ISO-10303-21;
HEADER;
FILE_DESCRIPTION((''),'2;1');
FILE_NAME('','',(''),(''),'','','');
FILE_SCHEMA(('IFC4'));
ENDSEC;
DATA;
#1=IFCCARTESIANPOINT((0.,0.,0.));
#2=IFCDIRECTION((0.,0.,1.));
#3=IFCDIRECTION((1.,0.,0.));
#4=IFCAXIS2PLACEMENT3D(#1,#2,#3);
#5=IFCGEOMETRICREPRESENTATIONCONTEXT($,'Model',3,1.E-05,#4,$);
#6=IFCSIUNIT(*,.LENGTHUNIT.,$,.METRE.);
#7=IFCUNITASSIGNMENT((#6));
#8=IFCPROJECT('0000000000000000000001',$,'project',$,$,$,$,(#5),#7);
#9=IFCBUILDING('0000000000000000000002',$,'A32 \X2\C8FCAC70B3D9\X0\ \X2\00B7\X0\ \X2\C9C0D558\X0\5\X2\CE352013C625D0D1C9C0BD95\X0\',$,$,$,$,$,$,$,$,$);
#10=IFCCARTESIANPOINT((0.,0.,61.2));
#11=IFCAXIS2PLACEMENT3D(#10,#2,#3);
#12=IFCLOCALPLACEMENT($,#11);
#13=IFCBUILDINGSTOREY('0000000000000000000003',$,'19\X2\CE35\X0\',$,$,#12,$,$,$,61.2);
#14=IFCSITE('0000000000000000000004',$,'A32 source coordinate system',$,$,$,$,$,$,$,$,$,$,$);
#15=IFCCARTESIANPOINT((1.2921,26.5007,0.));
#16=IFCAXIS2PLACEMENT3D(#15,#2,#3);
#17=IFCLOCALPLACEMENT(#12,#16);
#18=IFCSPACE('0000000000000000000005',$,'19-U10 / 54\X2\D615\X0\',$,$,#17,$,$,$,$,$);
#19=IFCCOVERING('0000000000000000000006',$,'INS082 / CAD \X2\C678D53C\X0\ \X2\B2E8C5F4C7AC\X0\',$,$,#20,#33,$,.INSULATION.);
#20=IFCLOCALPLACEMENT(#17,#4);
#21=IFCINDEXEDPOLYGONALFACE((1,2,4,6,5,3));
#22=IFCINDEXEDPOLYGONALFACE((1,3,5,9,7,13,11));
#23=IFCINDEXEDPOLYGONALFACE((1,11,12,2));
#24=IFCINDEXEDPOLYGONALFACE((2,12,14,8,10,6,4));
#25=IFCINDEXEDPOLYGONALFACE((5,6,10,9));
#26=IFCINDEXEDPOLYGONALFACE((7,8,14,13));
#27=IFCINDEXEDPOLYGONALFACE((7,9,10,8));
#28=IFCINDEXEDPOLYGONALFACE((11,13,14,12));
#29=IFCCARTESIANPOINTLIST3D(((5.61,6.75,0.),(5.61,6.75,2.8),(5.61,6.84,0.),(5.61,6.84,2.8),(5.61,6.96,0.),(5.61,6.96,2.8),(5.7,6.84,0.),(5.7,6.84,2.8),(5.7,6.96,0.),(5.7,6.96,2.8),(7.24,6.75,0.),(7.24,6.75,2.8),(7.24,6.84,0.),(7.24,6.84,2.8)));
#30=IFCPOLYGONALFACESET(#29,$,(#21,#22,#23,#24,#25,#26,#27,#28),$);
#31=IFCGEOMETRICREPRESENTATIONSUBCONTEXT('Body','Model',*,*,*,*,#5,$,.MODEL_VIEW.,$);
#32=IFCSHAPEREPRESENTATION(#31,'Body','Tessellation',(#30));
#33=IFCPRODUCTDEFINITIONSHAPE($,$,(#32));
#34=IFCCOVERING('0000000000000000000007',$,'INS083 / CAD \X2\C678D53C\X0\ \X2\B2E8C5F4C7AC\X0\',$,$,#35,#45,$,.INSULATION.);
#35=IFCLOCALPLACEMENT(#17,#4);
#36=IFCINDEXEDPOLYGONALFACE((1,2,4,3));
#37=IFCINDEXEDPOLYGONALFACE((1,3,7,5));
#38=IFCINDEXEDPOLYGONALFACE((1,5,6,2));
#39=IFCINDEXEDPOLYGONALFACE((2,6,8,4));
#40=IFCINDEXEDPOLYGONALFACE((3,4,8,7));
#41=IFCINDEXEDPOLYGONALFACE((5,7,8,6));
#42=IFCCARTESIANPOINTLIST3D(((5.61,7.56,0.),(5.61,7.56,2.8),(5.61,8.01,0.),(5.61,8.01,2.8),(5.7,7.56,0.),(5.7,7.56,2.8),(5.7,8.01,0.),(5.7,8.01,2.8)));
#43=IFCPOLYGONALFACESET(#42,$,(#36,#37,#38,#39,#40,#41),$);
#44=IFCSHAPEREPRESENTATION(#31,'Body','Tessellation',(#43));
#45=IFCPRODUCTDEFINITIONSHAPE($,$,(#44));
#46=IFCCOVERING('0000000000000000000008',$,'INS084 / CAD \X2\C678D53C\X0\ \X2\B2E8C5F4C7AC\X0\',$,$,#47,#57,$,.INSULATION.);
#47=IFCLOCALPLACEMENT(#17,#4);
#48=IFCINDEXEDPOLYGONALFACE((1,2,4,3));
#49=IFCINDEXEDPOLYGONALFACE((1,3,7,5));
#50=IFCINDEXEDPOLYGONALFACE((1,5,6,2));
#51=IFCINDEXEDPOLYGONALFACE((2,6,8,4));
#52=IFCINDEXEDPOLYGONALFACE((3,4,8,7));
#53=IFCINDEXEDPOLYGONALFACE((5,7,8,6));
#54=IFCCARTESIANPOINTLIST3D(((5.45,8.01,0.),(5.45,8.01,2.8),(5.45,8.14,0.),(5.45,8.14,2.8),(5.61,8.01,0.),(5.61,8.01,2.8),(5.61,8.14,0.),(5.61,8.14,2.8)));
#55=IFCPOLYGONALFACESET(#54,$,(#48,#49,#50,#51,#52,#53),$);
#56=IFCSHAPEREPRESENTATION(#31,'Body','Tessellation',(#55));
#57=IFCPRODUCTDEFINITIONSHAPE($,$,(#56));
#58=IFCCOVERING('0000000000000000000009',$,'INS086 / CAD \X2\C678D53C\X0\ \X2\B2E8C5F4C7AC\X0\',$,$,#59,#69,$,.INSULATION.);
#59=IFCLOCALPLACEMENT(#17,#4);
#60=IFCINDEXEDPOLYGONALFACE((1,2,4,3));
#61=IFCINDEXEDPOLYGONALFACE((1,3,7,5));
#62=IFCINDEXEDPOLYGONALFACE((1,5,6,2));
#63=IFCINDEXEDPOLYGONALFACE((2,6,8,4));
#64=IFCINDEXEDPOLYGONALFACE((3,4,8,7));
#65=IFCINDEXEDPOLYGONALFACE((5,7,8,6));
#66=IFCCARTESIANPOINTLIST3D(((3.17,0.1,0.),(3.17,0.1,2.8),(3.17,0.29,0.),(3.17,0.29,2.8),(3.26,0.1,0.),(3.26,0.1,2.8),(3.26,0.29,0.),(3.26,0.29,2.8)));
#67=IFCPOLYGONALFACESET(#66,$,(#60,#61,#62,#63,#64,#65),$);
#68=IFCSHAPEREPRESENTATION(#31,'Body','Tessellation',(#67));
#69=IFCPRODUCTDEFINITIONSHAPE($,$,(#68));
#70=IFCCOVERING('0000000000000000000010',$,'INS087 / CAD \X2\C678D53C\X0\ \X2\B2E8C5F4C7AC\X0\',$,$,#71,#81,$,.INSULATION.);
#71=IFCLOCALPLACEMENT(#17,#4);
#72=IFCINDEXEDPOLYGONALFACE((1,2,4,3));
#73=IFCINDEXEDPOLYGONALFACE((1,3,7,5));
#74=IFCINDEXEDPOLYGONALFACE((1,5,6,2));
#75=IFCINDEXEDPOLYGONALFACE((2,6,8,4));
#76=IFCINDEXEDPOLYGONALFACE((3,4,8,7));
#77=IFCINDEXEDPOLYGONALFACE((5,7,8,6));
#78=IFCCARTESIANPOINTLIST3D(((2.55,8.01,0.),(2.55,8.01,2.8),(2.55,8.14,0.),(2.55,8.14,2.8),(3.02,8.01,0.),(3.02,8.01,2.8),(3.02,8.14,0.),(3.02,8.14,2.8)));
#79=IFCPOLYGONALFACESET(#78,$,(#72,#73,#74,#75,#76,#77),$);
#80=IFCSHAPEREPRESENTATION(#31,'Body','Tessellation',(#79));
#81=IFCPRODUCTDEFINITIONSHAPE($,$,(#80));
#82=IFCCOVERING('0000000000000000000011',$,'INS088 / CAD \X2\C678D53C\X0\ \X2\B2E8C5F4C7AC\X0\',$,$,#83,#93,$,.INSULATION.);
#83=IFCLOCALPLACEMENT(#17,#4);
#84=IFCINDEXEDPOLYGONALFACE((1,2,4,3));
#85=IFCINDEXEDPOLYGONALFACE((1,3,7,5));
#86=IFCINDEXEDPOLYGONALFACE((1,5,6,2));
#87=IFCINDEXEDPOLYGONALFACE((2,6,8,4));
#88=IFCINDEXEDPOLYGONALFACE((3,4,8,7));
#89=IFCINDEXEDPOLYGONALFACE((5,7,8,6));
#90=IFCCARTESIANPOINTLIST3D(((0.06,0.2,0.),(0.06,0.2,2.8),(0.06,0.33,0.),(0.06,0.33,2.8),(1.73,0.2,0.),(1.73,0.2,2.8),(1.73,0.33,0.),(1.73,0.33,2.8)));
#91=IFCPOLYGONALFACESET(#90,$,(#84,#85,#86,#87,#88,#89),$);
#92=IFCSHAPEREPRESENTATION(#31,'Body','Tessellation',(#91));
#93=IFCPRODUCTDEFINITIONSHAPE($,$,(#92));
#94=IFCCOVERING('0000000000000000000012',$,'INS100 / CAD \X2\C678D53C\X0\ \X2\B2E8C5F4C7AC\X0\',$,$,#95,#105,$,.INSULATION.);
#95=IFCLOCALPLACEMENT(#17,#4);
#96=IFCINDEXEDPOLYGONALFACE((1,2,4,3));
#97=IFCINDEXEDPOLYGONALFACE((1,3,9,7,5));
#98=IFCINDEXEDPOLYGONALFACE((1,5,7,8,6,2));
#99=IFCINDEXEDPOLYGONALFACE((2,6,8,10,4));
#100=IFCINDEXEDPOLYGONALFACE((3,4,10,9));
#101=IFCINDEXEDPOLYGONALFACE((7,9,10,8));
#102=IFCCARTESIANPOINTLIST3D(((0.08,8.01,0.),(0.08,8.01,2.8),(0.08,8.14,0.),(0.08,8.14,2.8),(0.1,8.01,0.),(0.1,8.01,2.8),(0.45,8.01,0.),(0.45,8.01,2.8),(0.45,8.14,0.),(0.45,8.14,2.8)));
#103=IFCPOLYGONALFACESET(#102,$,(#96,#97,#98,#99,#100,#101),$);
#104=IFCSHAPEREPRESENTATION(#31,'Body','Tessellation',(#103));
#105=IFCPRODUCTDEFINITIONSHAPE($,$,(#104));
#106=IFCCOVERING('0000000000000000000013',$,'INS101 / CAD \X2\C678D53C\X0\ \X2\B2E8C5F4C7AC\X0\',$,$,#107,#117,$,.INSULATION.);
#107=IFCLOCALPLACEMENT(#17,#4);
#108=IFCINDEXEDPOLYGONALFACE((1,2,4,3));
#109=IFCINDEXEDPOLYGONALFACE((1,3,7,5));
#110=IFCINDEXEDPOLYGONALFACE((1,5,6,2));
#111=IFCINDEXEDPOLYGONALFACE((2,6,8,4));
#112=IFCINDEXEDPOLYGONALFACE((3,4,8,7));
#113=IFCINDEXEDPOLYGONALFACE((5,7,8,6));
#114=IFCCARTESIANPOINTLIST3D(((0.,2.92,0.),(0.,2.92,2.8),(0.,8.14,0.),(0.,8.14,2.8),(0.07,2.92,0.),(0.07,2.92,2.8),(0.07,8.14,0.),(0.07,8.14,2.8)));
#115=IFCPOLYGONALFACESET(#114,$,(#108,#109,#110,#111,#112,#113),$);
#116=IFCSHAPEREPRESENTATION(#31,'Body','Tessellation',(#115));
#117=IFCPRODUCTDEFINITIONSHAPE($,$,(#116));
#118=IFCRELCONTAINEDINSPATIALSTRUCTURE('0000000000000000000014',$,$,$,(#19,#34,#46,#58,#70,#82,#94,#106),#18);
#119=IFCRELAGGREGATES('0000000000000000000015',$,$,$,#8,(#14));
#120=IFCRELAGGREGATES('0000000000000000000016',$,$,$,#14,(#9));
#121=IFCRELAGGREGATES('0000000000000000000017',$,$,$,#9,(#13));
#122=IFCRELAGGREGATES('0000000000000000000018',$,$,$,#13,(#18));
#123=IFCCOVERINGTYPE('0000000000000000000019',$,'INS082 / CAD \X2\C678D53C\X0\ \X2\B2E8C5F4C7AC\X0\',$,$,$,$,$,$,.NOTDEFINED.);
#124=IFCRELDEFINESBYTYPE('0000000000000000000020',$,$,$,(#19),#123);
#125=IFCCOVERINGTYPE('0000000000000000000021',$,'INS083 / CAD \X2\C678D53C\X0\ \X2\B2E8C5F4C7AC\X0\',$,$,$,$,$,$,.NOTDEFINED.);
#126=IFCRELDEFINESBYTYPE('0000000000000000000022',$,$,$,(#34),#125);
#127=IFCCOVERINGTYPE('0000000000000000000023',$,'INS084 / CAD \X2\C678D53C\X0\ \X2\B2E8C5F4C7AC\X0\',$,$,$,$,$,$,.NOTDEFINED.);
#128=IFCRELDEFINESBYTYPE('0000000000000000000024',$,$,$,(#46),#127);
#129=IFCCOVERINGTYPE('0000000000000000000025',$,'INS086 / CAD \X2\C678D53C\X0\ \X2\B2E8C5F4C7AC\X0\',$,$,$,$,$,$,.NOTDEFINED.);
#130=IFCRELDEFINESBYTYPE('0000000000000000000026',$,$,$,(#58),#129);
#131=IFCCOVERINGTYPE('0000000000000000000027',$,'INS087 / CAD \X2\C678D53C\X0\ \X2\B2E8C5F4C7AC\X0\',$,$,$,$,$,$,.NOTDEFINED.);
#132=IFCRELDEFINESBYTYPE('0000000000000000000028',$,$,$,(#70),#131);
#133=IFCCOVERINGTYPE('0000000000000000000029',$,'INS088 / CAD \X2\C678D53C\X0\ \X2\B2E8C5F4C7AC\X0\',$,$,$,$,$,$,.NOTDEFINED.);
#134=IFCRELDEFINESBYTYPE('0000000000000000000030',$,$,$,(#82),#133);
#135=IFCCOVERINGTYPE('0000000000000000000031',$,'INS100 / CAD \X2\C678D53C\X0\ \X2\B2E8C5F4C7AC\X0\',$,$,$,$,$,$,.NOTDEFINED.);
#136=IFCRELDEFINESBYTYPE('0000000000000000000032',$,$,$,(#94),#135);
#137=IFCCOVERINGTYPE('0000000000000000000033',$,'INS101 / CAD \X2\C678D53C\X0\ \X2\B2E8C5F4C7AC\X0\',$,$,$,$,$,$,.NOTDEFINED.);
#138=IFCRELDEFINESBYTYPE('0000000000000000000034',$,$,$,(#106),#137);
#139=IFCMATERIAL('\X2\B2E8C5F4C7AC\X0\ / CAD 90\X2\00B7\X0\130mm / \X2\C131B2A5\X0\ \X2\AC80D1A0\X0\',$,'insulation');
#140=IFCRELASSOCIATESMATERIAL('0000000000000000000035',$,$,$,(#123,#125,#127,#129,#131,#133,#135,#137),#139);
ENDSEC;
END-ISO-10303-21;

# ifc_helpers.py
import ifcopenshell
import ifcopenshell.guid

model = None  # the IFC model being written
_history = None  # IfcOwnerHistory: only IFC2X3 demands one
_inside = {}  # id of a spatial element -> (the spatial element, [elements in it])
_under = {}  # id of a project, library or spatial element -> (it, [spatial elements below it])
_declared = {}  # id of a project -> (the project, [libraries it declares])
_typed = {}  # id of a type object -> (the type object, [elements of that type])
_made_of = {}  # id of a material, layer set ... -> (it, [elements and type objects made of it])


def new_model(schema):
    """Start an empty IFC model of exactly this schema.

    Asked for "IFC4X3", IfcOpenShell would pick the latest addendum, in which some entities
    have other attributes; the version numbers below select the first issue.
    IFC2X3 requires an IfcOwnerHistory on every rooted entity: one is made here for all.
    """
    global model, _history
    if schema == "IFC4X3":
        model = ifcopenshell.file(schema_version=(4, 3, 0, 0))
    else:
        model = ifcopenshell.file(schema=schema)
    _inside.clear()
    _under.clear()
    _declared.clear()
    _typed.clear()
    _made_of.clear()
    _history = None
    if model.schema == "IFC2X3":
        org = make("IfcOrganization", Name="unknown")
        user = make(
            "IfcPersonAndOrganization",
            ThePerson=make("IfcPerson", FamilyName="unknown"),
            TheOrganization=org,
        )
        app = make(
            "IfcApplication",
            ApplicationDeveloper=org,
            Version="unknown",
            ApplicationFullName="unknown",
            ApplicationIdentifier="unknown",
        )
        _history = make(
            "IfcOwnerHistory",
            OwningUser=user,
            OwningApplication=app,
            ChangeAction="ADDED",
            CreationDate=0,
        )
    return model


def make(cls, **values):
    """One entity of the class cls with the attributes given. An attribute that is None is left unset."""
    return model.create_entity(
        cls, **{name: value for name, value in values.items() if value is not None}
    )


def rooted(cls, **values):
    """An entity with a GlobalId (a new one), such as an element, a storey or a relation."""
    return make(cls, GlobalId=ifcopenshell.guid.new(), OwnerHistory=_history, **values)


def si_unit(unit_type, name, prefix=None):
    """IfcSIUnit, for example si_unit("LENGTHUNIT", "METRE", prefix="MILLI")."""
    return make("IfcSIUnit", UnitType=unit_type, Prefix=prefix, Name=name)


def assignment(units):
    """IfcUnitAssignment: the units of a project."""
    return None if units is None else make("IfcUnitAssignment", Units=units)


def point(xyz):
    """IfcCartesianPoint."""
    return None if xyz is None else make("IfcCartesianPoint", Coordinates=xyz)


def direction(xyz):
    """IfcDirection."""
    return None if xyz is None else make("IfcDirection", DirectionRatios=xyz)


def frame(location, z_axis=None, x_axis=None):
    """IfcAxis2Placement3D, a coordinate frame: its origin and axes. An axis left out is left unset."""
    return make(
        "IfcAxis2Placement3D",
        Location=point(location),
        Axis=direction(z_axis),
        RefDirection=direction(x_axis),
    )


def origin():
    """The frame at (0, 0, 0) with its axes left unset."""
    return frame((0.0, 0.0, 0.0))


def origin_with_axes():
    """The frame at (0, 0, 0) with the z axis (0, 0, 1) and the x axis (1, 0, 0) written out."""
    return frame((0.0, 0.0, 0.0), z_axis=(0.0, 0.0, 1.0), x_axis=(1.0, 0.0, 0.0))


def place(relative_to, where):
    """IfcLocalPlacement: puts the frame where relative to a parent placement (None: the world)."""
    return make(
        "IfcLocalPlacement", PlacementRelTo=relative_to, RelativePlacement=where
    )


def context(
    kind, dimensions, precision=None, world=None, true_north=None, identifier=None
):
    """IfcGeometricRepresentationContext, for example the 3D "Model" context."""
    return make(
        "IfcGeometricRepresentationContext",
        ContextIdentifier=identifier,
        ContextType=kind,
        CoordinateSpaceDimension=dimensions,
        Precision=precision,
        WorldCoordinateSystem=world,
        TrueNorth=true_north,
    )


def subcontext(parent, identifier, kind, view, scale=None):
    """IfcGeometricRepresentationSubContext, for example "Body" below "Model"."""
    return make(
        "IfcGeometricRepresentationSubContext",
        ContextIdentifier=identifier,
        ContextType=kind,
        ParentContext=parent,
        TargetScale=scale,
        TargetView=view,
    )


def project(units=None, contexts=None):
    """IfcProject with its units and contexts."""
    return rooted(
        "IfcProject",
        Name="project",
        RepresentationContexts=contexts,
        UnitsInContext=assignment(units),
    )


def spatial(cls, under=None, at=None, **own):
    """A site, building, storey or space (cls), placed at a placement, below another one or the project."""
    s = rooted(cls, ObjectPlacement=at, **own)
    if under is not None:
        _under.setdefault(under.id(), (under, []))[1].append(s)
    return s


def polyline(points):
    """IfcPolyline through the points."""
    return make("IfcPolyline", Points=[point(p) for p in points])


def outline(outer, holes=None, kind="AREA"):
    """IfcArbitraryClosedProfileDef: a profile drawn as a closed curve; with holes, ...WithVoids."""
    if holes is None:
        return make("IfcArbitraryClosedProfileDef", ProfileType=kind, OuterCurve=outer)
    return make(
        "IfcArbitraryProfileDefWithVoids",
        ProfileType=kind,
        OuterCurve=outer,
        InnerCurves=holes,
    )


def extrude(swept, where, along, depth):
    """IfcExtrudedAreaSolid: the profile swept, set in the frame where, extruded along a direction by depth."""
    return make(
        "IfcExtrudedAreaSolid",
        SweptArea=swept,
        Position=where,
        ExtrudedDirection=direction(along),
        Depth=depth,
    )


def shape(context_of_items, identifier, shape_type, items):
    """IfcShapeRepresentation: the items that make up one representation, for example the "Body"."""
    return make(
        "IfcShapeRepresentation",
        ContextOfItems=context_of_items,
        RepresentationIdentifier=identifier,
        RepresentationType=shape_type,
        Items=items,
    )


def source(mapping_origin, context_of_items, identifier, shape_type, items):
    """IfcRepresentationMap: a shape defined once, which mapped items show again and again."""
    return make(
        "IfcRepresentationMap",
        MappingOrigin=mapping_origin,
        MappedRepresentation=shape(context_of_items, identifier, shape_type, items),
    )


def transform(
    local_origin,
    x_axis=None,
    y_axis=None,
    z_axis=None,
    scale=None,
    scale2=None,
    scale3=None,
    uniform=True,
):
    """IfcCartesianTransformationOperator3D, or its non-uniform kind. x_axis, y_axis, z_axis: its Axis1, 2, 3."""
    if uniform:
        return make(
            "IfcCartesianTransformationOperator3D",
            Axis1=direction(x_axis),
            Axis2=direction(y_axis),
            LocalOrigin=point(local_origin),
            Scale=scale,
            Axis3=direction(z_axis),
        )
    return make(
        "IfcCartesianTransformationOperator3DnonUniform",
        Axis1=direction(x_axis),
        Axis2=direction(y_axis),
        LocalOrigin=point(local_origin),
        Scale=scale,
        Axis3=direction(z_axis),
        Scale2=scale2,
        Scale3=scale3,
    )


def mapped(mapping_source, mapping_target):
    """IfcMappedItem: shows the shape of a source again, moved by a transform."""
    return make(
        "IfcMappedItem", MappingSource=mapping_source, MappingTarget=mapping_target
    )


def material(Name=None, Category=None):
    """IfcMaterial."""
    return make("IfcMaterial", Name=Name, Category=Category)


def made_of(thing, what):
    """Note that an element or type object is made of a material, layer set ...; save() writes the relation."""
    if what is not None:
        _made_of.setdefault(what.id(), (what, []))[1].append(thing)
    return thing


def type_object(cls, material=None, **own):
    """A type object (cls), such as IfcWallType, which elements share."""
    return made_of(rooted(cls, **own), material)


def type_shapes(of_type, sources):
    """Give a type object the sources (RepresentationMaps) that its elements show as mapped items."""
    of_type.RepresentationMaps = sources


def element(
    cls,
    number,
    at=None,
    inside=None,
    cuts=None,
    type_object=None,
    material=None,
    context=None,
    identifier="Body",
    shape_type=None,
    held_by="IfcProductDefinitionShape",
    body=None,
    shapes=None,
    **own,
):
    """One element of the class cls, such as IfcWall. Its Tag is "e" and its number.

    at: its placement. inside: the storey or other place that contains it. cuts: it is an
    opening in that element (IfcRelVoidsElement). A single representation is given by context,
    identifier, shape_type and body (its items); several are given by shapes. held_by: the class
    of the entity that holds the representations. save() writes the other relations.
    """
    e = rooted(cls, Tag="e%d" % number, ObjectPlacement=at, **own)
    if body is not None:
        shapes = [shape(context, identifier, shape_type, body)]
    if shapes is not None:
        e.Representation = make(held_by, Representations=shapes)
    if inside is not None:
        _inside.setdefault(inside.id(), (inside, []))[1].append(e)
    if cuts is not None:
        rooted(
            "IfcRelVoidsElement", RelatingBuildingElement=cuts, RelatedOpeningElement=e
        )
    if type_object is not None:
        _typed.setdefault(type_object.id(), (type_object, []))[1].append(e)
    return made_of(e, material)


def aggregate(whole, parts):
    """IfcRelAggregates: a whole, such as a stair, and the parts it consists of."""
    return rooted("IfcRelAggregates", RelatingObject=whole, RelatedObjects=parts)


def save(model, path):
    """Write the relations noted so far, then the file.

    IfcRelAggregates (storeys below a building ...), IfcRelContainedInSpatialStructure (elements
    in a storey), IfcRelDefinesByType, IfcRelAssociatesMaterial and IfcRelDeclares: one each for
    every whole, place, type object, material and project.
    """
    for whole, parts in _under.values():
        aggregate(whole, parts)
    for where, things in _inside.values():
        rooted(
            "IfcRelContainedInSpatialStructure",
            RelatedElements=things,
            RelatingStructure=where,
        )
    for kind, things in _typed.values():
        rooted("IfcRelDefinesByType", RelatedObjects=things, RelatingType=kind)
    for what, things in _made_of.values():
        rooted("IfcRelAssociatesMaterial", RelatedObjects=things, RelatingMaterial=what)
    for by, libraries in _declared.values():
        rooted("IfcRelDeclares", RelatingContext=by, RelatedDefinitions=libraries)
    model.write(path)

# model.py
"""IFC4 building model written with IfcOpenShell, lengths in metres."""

from ifc_helpers import new_model, si_unit, frame, origin, origin_with_axes, place, context, subcontext, project, spatial, polyline, outline, extrude, source, transform, mapped, material, type_object, type_shapes, element, save


model = new_model("IFC4")

# Units and contexts
model_context = context("Model", 3, precision=1e-05, world=origin_with_axes())
body_context = subcontext(model_context, "Body", "Model", "MODEL_VIEW")
ifc_project = project(units=[si_unit("LENGTHUNIT", "METRE")], contexts=[model_context])

# Site, building, storey, space
storey_placement = place(None, frame((0.0, 0.0, 61.2), z_axis=(0.0, 0.0, 1.0), x_axis=(1.0, 0.0, 0.0)))
space_placement = place(storey_placement, frame((1.2921, 26.5007, 0.0), z_axis=(0.0, 0.0, 1.0), x_axis=(1.0, 0.0, 0.0)))
site = spatial("IfcSite", under=ifc_project, Name="A32 source coordinate system")
building = spatial("IfcBuilding", under=site, Name="A32 주거동 · 지하5층–옥탑지붕")
storey = spatial("IfcBuildingStorey", under=building, at=storey_placement, Name="19층", Elevation=61.2)
space = spatial("IfcSpace", under=storey, at=space_placement, Name="19-U10 / 54형")

# Coverings
ifc_material = material(Name="단열재 / CAD 90·130mm / 성능 검토", Category="insulation")
covering_type_1 = type_object("IfcCoveringType", Name="INS082 / CAD 외피 단열재", PredefinedType="NOTDEFINED", material=ifc_material)
shared_shape_1 = source(origin(), body_context, "Body", "SweptSolid", [
    extrude(outline(polyline([(5.61, 6.84), (5.61, 6.96), (5.7, 6.96), (5.7, 6.84), (7.24, 6.84), (7.24, 6.75), (5.61, 6.75), (5.61, 6.84)])), origin(), (0.0, 0.0, 1.0), 2.8),
])
type_shapes(covering_type_1, [shared_shape_1])
covering_1_placement = place(space_placement, origin_with_axes())
element("IfcCovering", 1, at=covering_1_placement, inside=space, type_object=covering_type_1, Name="INS082 / CAD 외피 단열재", PredefinedType="INSULATION", context=body_context, shape_type="MappedRepresentation", body=[
    mapped(shared_shape_1, transform((0.0, 0.0, 0.0), scale=1.0)),
])
covering_type_2 = type_object("IfcCoveringType", Name="INS083 / CAD 외피 단열재", PredefinedType="NOTDEFINED", material=ifc_material)
shared_shape_2 = source(origin(), body_context, "Body", "SweptSolid", [
    extrude(outline(polyline([(5.61, 8.01), (5.7, 8.01), (5.7, 7.56), (5.61, 7.56), (5.61, 8.01)])), origin(), (0.0, 0.0, 1.0), 2.8),
])
type_shapes(covering_type_2, [shared_shape_2])
covering_2_placement = place(space_placement, origin_with_axes())
element("IfcCovering", 2, at=covering_2_placement, inside=space, type_object=covering_type_2, Name="INS083 / CAD 외피 단열재", PredefinedType="INSULATION", context=body_context, shape_type="MappedRepresentation", body=[
    mapped(shared_shape_2, transform((0.0, 0.0, 0.0), scale=1.0)),
])
covering_type_3 = type_object("IfcCoveringType", Name="INS084 / CAD 외피 단열재", PredefinedType="NOTDEFINED", material=ifc_material)
shared_shape_3 = source(origin(), body_context, "Body", "SweptSolid", [
    extrude(outline(polyline([(5.45, 8.01), (5.45, 8.14), (5.61, 8.14), (5.61, 8.01), (5.45, 8.01)])), origin(), (0.0, 0.0, 1.0), 2.8),
])
type_shapes(covering_type_3, [shared_shape_3])
covering_3_placement = place(space_placement, origin_with_axes())
element("IfcCovering", 3, at=covering_3_placement, inside=space, type_object=covering_type_3, Name="INS084 / CAD 외피 단열재", PredefinedType="INSULATION", context=body_context, shape_type="MappedRepresentation", body=[
    mapped(shared_shape_3, transform((0.0, 0.0, 0.0), scale=1.0)),
])
covering_type_4 = type_object("IfcCoveringType", Name="INS086 / CAD 외피 단열재", PredefinedType="NOTDEFINED", material=ifc_material)
shared_shape_4 = source(origin(), body_context, "Body", "SweptSolid", [
    extrude(outline(polyline([(3.17, 0.1), (3.17, 0.29), (3.26, 0.29), (3.26, 0.1), (3.17, 0.1)])), origin(), (0.0, 0.0, 1.0), 2.8),
])
type_shapes(covering_type_4, [shared_shape_4])
covering_4_placement = place(space_placement, origin_with_axes())
element("IfcCovering", 4, at=covering_4_placement, inside=space, type_object=covering_type_4, Name="INS086 / CAD 외피 단열재", PredefinedType="INSULATION", context=body_context, shape_type="MappedRepresentation", body=[
    mapped(shared_shape_4, transform((0.0, 0.0, 0.0), scale=1.0)),
])
covering_type_5 = type_object("IfcCoveringType", Name="INS087 / CAD 외피 단열재", PredefinedType="NOTDEFINED", material=ifc_material)
shared_shape_5 = source(origin(), body_context, "Body", "SweptSolid", [
    extrude(outline(polyline([(2.55, 8.14), (3.02, 8.14), (3.02, 8.01), (2.55, 8.01), (2.55, 8.14)])), origin(), (0.0, 0.0, 1.0), 2.8),
])
type_shapes(covering_type_5, [shared_shape_5])
covering_5_placement = place(space_placement, origin_with_axes())
element("IfcCovering", 5, at=covering_5_placement, inside=space, type_object=covering_type_5, Name="INS087 / CAD 외피 단열재", PredefinedType="INSULATION", context=body_context, shape_type="MappedRepresentation", body=[
    mapped(shared_shape_5, transform((0.0, 0.0, 0.0), scale=1.0)),
])
covering_type_6 = type_object("IfcCoveringType", Name="INS088 / CAD 외피 단열재", PredefinedType="NOTDEFINED", material=ifc_material)
shared_shape_6 = source(origin(), body_context, "Body", "SweptSolid", [
    extrude(outline(polyline([(0.06, 0.33), (1.73, 0.33), (1.73, 0.2), (0.06, 0.2), (0.06, 0.33)])), origin(), (0.0, 0.0, 1.0), 2.8),
])
type_shapes(covering_type_6, [shared_shape_6])
covering_6_placement = place(space_placement, origin_with_axes())
element("IfcCovering", 6, at=covering_6_placement, inside=space, type_object=covering_type_6, Name="INS088 / CAD 외피 단열재", PredefinedType="INSULATION", context=body_context, shape_type="MappedRepresentation", body=[
    mapped(shared_shape_6, transform((0.0, 0.0, 0.0), scale=1.0)),
])
covering_type_7 = type_object("IfcCoveringType", Name="INS100 / CAD 외피 단열재", PredefinedType="NOTDEFINED", material=ifc_material)
shared_shape_7 = source(origin(), body_context, "Body", "SweptSolid", [
    extrude(outline(polyline([(0.08, 8.01), (0.08, 8.14), (0.45, 8.14), (0.45, 8.01), (0.1, 8.01), (0.08, 8.01)])), origin(), (0.0, 0.0, 1.0), 2.8),
])
type_shapes(covering_type_7, [shared_shape_7])
covering_7_placement = place(space_placement, origin_with_axes())
element("IfcCovering", 7, at=covering_7_placement, inside=space, type_object=covering_type_7, Name="INS100 / CAD 외피 단열재", PredefinedType="INSULATION", context=body_context, shape_type="MappedRepresentation", body=[
    mapped(shared_shape_7, transform((0.0, 0.0, 0.0), scale=1.0)),
])
covering_type_8 = type_object("IfcCoveringType", Name="INS101 / CAD 외피 단열재", PredefinedType="NOTDEFINED", material=ifc_material)
shared_shape_8 = source(origin(), body_context, "Body", "SweptSolid", [
    extrude(outline(polyline([(0.0, 2.92), (0.0, 8.14), (0.07, 8.14), (0.07, 2.92), (0.0, 2.92)])), origin(), (0.0, 0.0, 1.0), 2.8),
])
type_shapes(covering_type_8, [shared_shape_8])
covering_8_placement = place(space_placement, origin_with_axes())
element("IfcCovering", 8, at=covering_8_placement, inside=space, type_object=covering_type_8, Name="INS101 / CAD 외피 단열재", PredefinedType="INSULATION", context=body_context, shape_type="MappedRepresentation", body=[
    mapped(shared_shape_8, transform((0.0, 0.0, 0.0), scale=1.0)),
])

save(model, "model.ifc")
